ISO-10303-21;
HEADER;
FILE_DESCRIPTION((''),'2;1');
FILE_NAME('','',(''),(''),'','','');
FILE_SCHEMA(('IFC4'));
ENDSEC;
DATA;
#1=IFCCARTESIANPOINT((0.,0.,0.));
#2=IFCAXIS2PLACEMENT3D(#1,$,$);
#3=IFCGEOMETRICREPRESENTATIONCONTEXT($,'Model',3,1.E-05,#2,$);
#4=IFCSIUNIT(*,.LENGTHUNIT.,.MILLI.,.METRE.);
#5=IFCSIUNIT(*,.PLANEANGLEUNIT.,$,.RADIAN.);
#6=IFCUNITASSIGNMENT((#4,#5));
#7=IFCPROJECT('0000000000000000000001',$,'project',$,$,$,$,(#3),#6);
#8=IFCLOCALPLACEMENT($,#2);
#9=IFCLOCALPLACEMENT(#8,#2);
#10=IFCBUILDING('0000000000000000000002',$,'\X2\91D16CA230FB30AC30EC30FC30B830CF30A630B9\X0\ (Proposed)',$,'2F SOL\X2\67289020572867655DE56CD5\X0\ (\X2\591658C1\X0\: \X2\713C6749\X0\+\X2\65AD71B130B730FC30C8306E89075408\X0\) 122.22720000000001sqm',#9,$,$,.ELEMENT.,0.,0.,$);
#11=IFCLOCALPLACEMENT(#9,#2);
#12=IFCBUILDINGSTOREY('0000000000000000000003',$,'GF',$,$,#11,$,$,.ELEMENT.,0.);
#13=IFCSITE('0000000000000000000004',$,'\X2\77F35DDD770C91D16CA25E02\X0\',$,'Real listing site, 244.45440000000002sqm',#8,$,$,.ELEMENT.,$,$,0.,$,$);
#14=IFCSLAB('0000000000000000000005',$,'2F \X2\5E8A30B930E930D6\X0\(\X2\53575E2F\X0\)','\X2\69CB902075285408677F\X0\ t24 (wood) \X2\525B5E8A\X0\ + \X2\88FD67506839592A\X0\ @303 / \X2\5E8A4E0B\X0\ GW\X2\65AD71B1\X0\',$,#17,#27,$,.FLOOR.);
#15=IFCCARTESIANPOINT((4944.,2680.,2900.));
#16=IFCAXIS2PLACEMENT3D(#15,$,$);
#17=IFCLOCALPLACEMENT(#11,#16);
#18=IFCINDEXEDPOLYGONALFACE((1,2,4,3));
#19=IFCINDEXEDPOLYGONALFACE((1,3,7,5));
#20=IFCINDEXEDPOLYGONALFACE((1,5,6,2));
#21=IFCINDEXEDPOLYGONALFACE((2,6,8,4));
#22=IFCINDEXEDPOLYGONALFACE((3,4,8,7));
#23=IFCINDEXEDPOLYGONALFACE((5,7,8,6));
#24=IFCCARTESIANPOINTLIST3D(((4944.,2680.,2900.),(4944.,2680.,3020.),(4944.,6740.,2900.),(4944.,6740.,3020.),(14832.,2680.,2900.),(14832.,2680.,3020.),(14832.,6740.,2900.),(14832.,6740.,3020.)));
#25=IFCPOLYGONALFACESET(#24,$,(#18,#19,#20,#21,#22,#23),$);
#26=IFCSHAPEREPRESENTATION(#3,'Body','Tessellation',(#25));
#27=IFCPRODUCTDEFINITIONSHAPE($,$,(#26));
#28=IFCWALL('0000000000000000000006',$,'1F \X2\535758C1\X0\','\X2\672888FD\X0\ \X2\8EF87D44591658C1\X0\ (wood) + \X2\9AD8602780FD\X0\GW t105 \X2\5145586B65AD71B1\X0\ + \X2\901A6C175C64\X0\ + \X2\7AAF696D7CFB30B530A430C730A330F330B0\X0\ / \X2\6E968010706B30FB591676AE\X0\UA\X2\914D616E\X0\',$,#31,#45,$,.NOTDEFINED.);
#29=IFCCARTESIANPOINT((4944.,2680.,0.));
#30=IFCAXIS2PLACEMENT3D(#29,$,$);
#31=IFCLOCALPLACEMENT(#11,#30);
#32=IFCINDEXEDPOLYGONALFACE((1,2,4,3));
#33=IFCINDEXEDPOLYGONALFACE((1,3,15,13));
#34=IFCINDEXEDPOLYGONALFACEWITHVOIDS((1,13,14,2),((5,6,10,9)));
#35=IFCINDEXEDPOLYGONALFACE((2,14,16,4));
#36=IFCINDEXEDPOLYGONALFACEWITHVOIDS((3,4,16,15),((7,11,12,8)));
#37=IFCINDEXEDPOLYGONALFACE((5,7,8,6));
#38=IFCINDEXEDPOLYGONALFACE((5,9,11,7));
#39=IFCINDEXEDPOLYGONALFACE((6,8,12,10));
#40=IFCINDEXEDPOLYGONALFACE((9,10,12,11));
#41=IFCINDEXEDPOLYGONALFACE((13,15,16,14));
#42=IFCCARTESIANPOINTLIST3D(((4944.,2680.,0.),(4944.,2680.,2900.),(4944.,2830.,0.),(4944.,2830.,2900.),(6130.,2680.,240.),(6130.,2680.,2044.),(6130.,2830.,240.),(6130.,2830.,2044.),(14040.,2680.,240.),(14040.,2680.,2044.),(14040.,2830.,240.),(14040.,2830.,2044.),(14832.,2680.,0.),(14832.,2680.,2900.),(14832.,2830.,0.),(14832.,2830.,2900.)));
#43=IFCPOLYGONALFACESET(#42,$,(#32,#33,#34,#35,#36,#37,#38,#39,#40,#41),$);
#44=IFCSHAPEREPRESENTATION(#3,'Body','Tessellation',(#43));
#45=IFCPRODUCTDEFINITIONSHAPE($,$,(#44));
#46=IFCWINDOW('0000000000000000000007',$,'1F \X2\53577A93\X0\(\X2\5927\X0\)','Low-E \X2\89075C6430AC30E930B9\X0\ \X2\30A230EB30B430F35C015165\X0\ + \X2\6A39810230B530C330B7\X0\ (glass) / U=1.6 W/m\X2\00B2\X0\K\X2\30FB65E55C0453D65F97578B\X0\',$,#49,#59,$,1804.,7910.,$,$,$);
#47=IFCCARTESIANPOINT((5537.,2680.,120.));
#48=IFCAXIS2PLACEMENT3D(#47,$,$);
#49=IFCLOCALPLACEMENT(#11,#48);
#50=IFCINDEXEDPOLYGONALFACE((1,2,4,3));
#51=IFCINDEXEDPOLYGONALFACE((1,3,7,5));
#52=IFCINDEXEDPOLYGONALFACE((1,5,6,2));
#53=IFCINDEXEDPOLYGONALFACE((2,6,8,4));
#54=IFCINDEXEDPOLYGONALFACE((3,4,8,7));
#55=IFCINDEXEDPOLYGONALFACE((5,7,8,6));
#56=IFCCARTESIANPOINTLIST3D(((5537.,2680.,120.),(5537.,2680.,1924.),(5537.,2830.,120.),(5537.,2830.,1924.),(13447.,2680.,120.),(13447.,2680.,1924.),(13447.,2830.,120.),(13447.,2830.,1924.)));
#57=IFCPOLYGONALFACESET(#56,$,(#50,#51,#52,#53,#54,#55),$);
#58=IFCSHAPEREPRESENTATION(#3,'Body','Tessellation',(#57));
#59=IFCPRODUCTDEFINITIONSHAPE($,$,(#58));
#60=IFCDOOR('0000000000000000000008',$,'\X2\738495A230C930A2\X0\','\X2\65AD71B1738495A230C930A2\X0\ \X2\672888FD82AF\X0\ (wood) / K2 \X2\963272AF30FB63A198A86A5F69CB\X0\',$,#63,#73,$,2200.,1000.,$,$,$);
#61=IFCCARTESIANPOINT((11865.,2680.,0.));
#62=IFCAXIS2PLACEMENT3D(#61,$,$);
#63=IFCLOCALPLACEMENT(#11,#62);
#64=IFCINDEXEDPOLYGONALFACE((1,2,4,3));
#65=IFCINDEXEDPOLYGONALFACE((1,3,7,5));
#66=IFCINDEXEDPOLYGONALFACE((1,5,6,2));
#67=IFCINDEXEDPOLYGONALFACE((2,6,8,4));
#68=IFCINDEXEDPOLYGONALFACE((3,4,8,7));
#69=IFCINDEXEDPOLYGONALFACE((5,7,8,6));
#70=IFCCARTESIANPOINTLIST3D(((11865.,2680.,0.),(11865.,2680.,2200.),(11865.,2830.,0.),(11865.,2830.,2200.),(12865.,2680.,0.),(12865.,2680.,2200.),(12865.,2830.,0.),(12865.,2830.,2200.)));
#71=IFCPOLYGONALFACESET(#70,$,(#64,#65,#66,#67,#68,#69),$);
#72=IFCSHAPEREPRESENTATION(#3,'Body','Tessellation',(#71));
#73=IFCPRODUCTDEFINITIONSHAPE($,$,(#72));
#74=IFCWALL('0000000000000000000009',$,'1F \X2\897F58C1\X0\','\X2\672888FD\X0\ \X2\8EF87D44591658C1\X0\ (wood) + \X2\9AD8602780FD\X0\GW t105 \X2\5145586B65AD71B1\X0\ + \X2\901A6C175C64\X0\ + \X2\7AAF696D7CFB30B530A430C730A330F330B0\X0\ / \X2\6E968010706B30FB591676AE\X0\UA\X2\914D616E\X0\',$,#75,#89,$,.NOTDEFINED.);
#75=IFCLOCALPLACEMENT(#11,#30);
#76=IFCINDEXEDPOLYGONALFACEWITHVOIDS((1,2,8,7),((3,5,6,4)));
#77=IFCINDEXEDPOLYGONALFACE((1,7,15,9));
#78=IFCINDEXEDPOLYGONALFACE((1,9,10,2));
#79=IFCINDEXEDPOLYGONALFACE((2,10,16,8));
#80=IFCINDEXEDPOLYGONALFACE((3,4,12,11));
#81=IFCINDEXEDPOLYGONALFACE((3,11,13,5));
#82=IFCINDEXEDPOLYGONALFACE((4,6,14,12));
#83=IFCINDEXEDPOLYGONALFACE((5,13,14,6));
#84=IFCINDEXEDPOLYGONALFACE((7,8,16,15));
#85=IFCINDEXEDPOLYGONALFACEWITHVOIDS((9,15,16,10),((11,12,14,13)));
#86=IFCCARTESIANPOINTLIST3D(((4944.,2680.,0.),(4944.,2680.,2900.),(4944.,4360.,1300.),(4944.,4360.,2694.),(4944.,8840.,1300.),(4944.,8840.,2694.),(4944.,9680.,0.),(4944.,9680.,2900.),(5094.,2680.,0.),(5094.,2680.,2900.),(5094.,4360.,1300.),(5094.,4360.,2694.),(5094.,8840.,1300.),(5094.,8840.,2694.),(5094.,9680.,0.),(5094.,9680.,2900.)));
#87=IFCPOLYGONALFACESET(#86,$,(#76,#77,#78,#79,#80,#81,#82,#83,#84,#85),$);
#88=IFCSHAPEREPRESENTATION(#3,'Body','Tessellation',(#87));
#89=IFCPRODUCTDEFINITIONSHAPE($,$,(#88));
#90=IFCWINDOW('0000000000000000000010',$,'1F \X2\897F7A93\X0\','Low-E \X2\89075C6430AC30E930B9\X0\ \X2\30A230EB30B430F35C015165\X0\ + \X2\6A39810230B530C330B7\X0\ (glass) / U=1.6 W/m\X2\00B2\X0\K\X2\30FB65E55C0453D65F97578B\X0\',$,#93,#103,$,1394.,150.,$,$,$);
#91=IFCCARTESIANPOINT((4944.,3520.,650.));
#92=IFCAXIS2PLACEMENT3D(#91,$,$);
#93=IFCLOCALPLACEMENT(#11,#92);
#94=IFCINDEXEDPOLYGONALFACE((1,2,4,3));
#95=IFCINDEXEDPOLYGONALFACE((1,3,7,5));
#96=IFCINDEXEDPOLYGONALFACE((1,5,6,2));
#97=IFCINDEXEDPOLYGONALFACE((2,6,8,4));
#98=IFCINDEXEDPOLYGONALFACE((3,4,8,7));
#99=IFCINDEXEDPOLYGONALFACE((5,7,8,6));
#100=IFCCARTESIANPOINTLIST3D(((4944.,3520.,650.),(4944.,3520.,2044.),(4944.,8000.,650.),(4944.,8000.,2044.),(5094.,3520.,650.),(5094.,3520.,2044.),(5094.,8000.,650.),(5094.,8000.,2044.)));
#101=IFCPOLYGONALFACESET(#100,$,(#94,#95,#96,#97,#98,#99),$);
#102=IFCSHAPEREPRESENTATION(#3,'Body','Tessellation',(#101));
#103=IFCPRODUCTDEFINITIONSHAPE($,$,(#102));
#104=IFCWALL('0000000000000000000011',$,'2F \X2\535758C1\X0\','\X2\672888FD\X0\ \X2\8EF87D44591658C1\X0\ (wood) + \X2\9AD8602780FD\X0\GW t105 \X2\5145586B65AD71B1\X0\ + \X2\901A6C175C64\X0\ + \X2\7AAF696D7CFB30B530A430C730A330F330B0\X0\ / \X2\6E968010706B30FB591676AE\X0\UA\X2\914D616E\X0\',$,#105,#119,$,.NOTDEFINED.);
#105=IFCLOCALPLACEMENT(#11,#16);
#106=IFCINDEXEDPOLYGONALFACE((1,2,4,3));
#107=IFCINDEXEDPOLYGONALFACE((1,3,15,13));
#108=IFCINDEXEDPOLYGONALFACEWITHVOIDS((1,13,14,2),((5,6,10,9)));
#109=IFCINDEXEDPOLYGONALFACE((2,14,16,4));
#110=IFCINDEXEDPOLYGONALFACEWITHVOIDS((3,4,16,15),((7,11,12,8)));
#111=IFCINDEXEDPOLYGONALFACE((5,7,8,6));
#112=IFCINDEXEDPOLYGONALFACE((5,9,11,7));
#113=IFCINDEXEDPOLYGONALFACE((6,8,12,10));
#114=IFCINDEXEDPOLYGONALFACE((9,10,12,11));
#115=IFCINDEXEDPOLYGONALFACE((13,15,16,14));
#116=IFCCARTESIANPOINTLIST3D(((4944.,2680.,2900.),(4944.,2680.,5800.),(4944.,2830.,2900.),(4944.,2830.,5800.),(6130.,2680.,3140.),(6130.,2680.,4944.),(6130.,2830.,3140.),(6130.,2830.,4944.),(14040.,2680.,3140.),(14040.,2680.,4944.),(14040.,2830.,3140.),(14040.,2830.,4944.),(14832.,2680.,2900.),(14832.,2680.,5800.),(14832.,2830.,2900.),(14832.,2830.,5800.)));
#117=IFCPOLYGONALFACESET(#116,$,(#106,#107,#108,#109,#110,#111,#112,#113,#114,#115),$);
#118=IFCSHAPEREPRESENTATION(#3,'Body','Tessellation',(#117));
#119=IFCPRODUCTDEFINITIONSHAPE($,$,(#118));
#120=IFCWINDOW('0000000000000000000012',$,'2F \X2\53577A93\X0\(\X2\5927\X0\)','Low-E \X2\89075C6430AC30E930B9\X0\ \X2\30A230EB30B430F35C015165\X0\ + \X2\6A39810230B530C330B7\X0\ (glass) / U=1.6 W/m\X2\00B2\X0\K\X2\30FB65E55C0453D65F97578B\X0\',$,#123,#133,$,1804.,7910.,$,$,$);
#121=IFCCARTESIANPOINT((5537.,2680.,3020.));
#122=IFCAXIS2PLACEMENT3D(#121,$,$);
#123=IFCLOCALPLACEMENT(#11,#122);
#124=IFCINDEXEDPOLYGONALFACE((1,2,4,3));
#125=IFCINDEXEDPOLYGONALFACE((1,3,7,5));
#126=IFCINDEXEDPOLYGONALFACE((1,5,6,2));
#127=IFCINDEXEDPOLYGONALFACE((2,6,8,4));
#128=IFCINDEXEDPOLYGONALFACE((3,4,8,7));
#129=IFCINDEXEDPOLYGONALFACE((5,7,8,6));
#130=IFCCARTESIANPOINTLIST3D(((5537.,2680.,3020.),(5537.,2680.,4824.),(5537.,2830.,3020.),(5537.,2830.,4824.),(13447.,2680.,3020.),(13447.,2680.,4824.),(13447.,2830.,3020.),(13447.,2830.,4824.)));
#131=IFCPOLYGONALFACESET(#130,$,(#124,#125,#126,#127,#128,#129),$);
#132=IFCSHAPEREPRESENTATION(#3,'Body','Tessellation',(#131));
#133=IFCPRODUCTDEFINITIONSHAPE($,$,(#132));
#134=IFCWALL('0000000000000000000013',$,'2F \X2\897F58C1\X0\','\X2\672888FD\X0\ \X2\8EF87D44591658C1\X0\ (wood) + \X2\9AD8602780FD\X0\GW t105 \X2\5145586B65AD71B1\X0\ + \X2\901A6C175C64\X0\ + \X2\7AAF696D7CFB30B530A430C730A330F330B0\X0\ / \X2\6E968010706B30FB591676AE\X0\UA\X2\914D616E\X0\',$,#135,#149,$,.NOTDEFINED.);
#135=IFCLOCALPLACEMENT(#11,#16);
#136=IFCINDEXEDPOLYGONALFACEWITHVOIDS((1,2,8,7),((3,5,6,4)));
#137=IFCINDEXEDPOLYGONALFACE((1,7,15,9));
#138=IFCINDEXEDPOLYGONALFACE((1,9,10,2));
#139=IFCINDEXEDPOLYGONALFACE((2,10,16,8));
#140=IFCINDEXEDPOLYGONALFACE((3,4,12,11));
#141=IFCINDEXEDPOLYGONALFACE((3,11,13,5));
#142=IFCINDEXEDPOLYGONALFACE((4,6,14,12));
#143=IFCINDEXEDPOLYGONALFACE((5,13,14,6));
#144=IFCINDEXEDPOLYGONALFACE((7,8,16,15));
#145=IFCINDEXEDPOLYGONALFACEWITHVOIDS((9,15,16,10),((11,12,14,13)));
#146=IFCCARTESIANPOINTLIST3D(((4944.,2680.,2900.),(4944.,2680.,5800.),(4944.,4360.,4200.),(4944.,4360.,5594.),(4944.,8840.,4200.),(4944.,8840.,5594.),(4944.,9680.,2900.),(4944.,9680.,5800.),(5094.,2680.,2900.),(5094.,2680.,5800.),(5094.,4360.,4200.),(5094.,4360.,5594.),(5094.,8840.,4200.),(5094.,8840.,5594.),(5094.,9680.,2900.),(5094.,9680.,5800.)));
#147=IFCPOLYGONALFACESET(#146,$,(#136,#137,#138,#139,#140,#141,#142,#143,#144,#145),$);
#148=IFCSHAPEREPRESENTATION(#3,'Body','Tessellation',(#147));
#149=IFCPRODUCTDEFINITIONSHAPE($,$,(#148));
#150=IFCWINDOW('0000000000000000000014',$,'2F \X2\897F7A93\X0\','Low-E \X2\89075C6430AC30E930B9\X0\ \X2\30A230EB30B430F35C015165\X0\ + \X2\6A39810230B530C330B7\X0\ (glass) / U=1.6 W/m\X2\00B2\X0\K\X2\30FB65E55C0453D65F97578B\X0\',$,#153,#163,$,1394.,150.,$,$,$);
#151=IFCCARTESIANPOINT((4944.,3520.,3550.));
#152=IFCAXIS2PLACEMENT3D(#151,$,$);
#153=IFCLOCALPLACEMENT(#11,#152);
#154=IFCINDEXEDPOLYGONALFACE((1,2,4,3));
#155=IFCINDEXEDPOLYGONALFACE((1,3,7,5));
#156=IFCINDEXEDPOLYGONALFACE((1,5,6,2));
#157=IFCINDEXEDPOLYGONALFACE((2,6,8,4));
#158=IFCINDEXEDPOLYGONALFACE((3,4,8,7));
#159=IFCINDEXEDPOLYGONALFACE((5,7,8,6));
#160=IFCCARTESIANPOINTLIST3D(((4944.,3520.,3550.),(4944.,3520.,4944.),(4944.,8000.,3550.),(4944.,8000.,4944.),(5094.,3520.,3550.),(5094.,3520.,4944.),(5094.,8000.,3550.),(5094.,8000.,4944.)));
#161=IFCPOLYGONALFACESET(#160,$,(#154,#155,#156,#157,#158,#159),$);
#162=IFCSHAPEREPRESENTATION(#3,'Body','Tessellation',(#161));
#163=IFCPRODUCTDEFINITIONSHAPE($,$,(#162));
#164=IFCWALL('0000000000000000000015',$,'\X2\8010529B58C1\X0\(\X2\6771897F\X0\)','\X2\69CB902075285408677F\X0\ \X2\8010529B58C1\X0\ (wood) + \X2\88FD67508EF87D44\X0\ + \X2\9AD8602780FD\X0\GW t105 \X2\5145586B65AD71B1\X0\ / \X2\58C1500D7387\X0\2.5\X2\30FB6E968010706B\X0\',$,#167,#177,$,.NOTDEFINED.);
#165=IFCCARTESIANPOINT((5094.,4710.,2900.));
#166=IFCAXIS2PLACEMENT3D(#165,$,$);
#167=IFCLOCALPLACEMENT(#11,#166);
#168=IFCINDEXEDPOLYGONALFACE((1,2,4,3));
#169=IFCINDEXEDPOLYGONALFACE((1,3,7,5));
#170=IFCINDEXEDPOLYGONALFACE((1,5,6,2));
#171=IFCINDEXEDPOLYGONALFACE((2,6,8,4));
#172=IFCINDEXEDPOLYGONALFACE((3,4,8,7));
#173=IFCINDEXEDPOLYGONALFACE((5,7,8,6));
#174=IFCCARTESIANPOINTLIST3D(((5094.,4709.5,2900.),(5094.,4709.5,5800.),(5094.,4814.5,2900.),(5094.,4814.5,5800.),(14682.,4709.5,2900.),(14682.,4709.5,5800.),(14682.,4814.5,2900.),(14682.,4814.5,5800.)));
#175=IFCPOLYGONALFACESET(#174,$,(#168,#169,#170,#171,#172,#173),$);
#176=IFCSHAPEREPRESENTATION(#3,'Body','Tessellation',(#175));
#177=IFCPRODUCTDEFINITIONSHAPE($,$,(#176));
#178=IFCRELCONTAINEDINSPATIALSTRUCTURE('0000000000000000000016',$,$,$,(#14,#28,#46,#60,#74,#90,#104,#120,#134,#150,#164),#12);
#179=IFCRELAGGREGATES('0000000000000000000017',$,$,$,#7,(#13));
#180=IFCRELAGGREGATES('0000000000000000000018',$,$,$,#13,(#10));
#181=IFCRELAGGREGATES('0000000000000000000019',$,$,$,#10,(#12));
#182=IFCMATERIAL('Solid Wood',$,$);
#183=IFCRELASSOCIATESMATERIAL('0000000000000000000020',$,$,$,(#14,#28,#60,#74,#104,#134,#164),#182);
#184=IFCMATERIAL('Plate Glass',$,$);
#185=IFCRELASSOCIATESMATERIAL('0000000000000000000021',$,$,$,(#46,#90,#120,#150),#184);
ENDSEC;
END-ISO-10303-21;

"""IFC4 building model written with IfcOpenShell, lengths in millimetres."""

from ifc_helpers import new_model, si_unit, frame, frame_2d, origin, place, context, project, spatial, rectangle, extrude, material, element, fill, save


model = new_model("IFC4")

# Units and contexts
model_context = context("Model", 3, precision=1e-05, world=origin())
ifc_project = project(units=[si_unit("LENGTHUNIT", "METRE", prefix="MILLI"), si_unit("PLANEANGLEUNIT", "RADIAN")], contexts=[model_context])

# Site, building, storey
site_placement = place(None, origin())
site = spatial("IfcSite", under=ifc_project, at=site_placement, Name="石川県金沢市", ObjectType="Real listing site, 244.45440000000002sqm", CompositionType="ELEMENT", RefElevation=0.0)
building_placement = place(site_placement, origin())
building = spatial("IfcBuilding", under=site, at=building_placement, Name="金沢・ガレージハウス (Proposed)", ObjectType="2F SOL木造在来工法 (外壁: 焼杉+断熱シートの複合) 122.22720000000001sqm", CompositionType="ELEMENT", ElevationOfRefHeight=0.0, ElevationOfTerrain=0.0)
storey_placement = place(building_placement, origin())
storey = spatial("IfcBuildingStorey", under=building, at=storey_placement, Name="GF", CompositionType="ELEMENT", Elevation=0.0)

# Slab
ifc_material_1 = material(Name="Solid Wood")
slab_1_placement = place(storey_placement, frame((4944.0, 2680.0, 2900.0)))
element("IfcSlab", 1, at=slab_1_placement, inside=storey, material=ifc_material_1, Name="2F 床スラブ(南帯)", Description="構造用合板 t24 (wood) 剛床 + 製材根太 @303 / 床下 GW断熱", PredefinedType="FLOOR", context=model_context, shape_type="SweptSolid", body=[
    extrude(rectangle(XDim=9888.0, YDim=4060.0, at=frame_2d((4944.0, 2030.0))), frame((4944.0, 2680.0, 2900.0)), (0.0, 0.0, 1.0), 120.0),
])

# Wall, openings, window, door
wall_1_placement = place(storey_placement, frame((4944.0, 2680.0, 0.0)))
wall_1 = element("IfcWall", 2, at=wall_1_placement, inside=storey, material=ifc_material_1, Name="1F 南壁", Description="木製 軸組外壁 (wood) + 高性能GW t105 充填断熱 + 通気層 + 窯業系サイディング / 準耐火・外皮UA配慮", PredefinedType="NOTDEFINED", context=model_context, shape_type="SweptSolid", body=[
    extrude(rectangle(XDim=9888.0, YDim=150.0, at=frame_2d((4944.0, 75.0))), frame((4944.0, 2680.0, 0.0)), (0.0, 0.0, 1.0), 2900.0),
])
opening_1_placement = place(storey_placement, frame((5537.0, 2680.0, 120.0)))
opening_1 = element("IfcOpeningElement", 3, at=opening_1_placement, cuts=wall_1, PredefinedType="NOTDEFINED", context=model_context, shape_type="SweptSolid", body=[
    extrude(rectangle(XDim=7910.0, YDim=150.0, at=frame_2d((3955.0, 75.0))), frame((5537.0, 2680.0, 120.0)), (0.0, 0.0, 1.0), 1804.0),
])
opening_2_placement = place(storey_placement, frame((11865.0, 2680.0, 0.0)))
opening_2 = element("IfcOpeningElement", 4, at=opening_2_placement, cuts=wall_1, PredefinedType="NOTDEFINED", context=model_context, shape_type="SweptSolid", body=[
    extrude(rectangle(XDim=1000.0, YDim=150.0, at=frame_2d((500.0, 75.0))), frame((11865.0, 2680.0, 0.0)), (0.0, 0.0, 1.0), 2200.0),
])
ifc_material_2 = material(Name="Plate Glass")
window_1_placement = place(storey_placement, frame((5537.0, 2680.0, 120.0)))
window_1 = element("IfcWindow", 5, at=window_1_placement, inside=storey, material=ifc_material_2, Name="1F 南窓(大)", Description="Low-E 複層ガラス アルゴン封入 + 樹脂サッシ (glass) / U=1.6 W/m²K・日射取得型", OverallHeight=1804.0, OverallWidth=7910.0, context=model_context, shape_type="SweptSolid", body=[
    extrude(rectangle(XDim=7910.0, YDim=150.0, at=frame_2d((3955.0, 75.0))), frame((5537.0, 2680.0, 120.0)), (0.0, 0.0, 1.0), 1804.0),
])
fill(opening_1, window_1)
door_placement = place(storey_placement, frame((11865.0, 2680.0, 0.0)))
door = element("IfcDoor", 6, at=door_placement, inside=storey, material=ifc_material_1, Name="玄関ドア", Description="断熱玄関ドア 木製芯 (wood) / K2 防犯・採風機構", OverallHeight=2200.0, OverallWidth=1000.0, context=model_context, shape_type="SweptSolid", body=[
    extrude(rectangle(XDim=1000.0, YDim=150.0, at=frame_2d((500.0, 75.0))), frame((11865.0, 2680.0, 0.0)), (0.0, 0.0, 1.0), 2200.0),
])
fill(opening_2, door)

# Wall, opening, window
wall_2_placement = place(storey_placement, frame((4944.0, 2680.0, 0.0)))
wall_2 = element("IfcWall", 7, at=wall_2_placement, inside=storey, material=ifc_material_1, Name="1F 西壁", Description="木製 軸組外壁 (wood) + 高性能GW t105 充填断熱 + 通気層 + 窯業系サイディング / 準耐火・外皮UA配慮", PredefinedType="NOTDEFINED", context=model_context, shape_type="SweptSolid", body=[
    extrude(rectangle(XDim=150.0, YDim=7000.0, at=frame_2d((75.0, 3500.0))), frame((4944.0, 2680.0, 0.0)), (0.0, 0.0, 1.0), 2900.0),
])
opening_3_placement = place(storey_placement, frame((4944.0, 3520.0, 650.0)))
opening_3 = element("IfcOpeningElement", 8, at=opening_3_placement, cuts=wall_2, PredefinedType="NOTDEFINED", context=model_context, shape_type="SweptSolid", body=[
    extrude(rectangle(XDim=150.0, YDim=4480.0, at=frame_2d((75.0, 2240.0))), frame((4944.0, 3520.0, 650.0)), (0.0, 0.0, 1.0), 1394.0),
])
window_2_placement = place(storey_placement, frame((4944.0, 3520.0, 650.0)))
window_2 = element("IfcWindow", 9, at=window_2_placement, inside=storey, material=ifc_material_2, Name="1F 西窓", Description="Low-E 複層ガラス アルゴン封入 + 樹脂サッシ (glass) / U=1.6 W/m²K・日射取得型", OverallHeight=1394.0, OverallWidth=150.0, context=model_context, shape_type="SweptSolid", body=[
    extrude(rectangle(XDim=150.0, YDim=4480.0, at=frame_2d((75.0, 2240.0))), frame((4944.0, 3520.0, 650.0)), (0.0, 0.0, 1.0), 1394.0),
])
fill(opening_3, window_2)

# Walls, openings, windows
wall_3_placement = place(storey_placement, frame((4944.0, 2680.0, 2900.0)))
wall_3 = element("IfcWall", 10, at=wall_3_placement, inside=storey, material=ifc_material_1, Name="2F 南壁", Description="木製 軸組外壁 (wood) + 高性能GW t105 充填断熱 + 通気層 + 窯業系サイディング / 準耐火・外皮UA配慮", PredefinedType="NOTDEFINED", context=model_context, shape_type="SweptSolid", body=[
    extrude(rectangle(XDim=9888.0, YDim=150.0, at=frame_2d((4944.0, 75.0))), frame((4944.0, 2680.0, 2900.0)), (0.0, 0.0, 1.0), 2900.0),
])
opening_4_placement = place(storey_placement, frame((5537.0, 2680.0, 3020.0)))
opening_4 = element("IfcOpeningElement", 11, at=opening_4_placement, cuts=wall_3, PredefinedType="NOTDEFINED", context=model_context, shape_type="SweptSolid", body=[
    extrude(rectangle(XDim=7910.0, YDim=150.0, at=frame_2d((3955.0, 75.0))), frame((5537.0, 2680.0, 3020.0)), (0.0, 0.0, 1.0), 1804.0),
])
window_3_placement = place(storey_placement, frame((5537.0, 2680.0, 3020.0)))
window_3 = element("IfcWindow", 12, at=window_3_placement, inside=storey, material=ifc_material_2, Name="2F 南窓(大)", Description="Low-E 複層ガラス アルゴン封入 + 樹脂サッシ (glass) / U=1.6 W/m²K・日射取得型", OverallHeight=1804.0, OverallWidth=7910.0, context=model_context, shape_type="SweptSolid", body=[
    extrude(rectangle(XDim=7910.0, YDim=150.0, at=frame_2d((3955.0, 75.0))), frame((5537.0, 2680.0, 3020.0)), (0.0, 0.0, 1.0), 1804.0),
])
fill(opening_4, window_3)
wall_4_placement = place(storey_placement, frame((4944.0, 2680.0, 2900.0)))
wall_4 = element("IfcWall", 13, at=wall_4_placement, inside=storey, material=ifc_material_1, Name="2F 西壁", Description="木製 軸組外壁 (wood) + 高性能GW t105 充填断熱 + 通気層 + 窯業系サイディング / 準耐火・外皮UA配慮", PredefinedType="NOTDEFINED", context=model_context, shape_type="SweptSolid", body=[
    extrude(rectangle(XDim=150.0, YDim=7000.0, at=frame_2d((75.0, 3500.0))), frame((4944.0, 2680.0, 2900.0)), (0.0, 0.0, 1.0), 2900.0),
])
opening_5_placement = place(storey_placement, frame((4944.0, 3520.0, 3550.0)))
opening_5 = element("IfcOpeningElement", 14, at=opening_5_placement, cuts=wall_4, PredefinedType="NOTDEFINED", context=model_context, shape_type="SweptSolid", body=[
    extrude(rectangle(XDim=150.0, YDim=4480.0, at=frame_2d((75.0, 2240.0))), frame((4944.0, 3520.0, 3550.0)), (0.0, 0.0, 1.0), 1394.0),
])
window_4_placement = place(storey_placement, frame((4944.0, 3520.0, 3550.0)))
window_4 = element("IfcWindow", 15, at=window_4_placement, inside=storey, material=ifc_material_2, Name="2F 西窓", Description="Low-E 複層ガラス アルゴン封入 + 樹脂サッシ (glass) / U=1.6 W/m²K・日射取得型", OverallHeight=1394.0, OverallWidth=150.0, context=model_context, shape_type="SweptSolid", body=[
    extrude(rectangle(XDim=150.0, YDim=4480.0, at=frame_2d((75.0, 2240.0))), frame((4944.0, 3520.0, 3550.0)), (0.0, 0.0, 1.0), 1394.0),
])
fill(opening_5, window_4)

# Wall
wall_5_placement = place(storey_placement, frame((5094.0, 4710.0, 2900.0)))
element("IfcWall", 16, at=wall_5_placement, inside=storey, material=ifc_material_1, Name="耐力壁(東西)", Description="構造用合板 耐力壁 (wood) + 製材軸組 + 高性能GW t105 充填断熱 / 壁倍率2.5・準耐火", PredefinedType="NOTDEFINED", context=model_context, shape_type="SweptSolid", body=[
    extrude(rectangle(XDim=9588.0, YDim=105.0, at=frame_2d((4794.0, 52.0))), frame((5094.0, 4710.0, 2900.0)), (0.0, 0.0, 1.0), 2900.0),
])

save(model, "model.ifc")
